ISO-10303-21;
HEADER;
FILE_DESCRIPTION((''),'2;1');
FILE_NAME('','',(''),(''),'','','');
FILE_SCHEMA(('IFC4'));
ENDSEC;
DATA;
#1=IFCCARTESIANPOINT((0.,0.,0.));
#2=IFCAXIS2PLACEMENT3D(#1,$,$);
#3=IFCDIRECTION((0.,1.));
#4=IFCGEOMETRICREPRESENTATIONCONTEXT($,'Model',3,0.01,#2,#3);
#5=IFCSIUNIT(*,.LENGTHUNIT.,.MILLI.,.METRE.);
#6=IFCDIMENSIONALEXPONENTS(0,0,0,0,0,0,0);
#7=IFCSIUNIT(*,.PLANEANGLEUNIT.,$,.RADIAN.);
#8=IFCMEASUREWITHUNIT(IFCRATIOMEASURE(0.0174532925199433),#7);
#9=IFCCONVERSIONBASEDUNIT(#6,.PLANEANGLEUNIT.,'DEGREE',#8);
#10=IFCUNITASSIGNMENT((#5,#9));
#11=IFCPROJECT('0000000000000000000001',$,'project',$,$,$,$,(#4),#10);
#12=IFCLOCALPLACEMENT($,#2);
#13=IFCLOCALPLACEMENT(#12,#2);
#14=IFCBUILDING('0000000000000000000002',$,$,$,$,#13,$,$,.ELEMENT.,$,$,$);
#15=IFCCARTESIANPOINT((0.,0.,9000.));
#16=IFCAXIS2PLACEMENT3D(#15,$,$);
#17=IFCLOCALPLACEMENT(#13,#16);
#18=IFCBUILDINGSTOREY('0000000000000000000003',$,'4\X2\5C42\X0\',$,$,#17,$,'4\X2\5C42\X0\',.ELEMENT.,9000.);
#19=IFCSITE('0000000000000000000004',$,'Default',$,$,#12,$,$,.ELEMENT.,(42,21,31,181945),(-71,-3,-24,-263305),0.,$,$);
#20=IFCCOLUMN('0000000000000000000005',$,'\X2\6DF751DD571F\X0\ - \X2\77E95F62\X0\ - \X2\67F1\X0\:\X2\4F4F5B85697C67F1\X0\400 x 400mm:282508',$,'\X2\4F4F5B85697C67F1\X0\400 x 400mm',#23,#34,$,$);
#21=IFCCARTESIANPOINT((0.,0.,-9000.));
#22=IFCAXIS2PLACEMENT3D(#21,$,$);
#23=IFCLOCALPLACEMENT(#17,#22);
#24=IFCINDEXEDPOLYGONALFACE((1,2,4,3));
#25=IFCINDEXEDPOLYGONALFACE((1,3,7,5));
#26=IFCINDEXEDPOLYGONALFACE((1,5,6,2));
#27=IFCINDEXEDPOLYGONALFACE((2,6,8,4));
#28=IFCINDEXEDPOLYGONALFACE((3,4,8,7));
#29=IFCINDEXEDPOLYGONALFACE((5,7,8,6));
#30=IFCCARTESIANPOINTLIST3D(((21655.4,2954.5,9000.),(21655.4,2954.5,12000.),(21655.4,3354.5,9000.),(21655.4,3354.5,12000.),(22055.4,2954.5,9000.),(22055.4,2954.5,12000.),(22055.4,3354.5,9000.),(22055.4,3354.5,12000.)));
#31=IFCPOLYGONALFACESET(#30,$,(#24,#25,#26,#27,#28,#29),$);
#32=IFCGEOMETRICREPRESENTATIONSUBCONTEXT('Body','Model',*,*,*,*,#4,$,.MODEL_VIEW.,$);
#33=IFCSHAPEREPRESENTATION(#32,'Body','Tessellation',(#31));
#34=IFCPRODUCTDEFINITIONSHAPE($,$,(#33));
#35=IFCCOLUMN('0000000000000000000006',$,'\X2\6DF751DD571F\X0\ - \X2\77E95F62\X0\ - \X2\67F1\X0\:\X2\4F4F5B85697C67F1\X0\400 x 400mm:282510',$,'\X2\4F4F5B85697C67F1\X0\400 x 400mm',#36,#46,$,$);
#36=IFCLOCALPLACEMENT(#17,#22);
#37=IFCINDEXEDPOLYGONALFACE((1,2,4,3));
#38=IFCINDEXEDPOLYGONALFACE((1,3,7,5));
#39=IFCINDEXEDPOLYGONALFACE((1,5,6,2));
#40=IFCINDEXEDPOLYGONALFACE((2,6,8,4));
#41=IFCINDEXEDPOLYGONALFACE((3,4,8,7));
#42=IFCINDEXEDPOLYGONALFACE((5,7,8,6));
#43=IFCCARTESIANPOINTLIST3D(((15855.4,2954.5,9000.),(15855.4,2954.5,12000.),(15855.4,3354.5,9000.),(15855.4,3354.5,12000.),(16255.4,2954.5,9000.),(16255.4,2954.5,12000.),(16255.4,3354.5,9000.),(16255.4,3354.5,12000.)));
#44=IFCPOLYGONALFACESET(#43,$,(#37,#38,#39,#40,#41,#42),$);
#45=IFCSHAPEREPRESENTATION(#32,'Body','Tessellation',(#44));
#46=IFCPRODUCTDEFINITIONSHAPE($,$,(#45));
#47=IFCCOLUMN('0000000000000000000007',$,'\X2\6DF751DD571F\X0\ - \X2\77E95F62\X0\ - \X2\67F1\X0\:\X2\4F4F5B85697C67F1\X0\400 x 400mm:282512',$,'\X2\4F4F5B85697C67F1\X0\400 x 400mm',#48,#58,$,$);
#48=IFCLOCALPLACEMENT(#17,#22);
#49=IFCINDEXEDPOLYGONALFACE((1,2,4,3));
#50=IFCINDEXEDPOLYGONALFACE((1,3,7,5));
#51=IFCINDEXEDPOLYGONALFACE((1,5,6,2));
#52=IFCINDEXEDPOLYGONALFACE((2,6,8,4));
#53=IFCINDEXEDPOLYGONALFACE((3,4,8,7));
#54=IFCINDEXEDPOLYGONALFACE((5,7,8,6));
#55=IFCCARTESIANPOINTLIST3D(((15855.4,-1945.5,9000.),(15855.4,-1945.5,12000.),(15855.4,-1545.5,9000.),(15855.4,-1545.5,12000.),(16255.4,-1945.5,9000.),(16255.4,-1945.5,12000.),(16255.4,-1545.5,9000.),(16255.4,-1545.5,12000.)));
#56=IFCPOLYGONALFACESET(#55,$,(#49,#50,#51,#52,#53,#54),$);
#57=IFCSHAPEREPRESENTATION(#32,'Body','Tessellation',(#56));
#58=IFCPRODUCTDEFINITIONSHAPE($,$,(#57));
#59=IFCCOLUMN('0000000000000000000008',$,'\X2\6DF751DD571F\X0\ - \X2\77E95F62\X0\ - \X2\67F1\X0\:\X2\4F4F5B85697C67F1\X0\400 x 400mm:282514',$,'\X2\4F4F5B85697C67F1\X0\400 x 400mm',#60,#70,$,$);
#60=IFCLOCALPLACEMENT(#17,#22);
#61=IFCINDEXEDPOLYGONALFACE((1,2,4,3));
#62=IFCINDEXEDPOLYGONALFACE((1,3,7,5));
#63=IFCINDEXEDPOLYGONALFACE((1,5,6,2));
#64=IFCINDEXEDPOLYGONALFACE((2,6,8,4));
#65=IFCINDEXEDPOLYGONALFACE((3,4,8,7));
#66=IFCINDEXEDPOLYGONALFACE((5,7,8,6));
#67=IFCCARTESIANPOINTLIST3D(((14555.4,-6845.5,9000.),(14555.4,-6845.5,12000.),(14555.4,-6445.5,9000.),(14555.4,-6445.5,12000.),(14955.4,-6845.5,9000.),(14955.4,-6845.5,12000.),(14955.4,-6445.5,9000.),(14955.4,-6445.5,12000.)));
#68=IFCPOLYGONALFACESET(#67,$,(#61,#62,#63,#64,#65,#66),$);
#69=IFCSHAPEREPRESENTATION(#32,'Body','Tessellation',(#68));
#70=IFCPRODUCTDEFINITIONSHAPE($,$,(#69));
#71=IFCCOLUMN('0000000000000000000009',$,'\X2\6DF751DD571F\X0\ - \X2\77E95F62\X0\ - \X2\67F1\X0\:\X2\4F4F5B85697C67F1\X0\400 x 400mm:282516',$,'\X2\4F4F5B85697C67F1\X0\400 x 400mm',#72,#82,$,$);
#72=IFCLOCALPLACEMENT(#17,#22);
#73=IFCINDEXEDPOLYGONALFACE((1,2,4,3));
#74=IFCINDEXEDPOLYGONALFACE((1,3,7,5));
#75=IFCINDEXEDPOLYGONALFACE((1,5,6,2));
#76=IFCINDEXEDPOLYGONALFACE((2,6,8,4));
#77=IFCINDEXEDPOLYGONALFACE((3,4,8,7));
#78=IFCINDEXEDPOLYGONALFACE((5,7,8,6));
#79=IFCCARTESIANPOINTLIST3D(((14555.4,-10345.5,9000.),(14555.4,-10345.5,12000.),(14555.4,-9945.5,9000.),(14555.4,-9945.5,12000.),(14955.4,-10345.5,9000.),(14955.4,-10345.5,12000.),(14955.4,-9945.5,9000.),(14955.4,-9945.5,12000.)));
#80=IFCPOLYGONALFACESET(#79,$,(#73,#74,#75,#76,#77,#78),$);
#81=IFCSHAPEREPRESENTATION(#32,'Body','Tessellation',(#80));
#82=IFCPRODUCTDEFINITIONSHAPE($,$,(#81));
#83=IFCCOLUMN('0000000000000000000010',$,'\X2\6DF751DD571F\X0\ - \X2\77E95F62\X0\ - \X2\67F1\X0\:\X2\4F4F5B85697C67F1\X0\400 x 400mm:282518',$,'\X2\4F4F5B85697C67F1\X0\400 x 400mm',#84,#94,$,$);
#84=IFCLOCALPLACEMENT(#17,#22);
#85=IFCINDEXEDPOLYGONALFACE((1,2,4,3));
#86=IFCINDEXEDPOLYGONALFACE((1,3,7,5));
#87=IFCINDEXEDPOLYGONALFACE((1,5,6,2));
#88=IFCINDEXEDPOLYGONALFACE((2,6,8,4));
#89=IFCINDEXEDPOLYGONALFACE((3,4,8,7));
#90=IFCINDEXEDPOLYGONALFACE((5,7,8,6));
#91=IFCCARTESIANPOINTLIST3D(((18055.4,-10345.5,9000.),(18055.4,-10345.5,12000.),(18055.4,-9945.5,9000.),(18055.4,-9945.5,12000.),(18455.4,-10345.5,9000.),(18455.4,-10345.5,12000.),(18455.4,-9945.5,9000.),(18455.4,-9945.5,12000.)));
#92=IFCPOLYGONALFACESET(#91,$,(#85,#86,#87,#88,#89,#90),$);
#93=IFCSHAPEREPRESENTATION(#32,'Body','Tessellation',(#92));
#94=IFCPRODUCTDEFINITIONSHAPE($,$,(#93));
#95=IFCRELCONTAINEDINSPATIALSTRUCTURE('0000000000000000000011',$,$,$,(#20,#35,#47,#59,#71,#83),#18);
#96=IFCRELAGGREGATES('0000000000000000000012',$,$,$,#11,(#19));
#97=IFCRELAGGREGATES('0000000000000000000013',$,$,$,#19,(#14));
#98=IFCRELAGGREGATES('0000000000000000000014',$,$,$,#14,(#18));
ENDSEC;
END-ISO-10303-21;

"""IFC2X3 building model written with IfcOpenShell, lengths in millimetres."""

from ifc_helpers import new_model, entity, si_unit, converted_unit, direction, frame, frame_2d, origin, origin_2d_with_axis, place, context, subcontext, project, spatial, rectangle, extrude, source, transform, mapped, element, save


model = new_model("IFC2X3")

# Units and contexts
model_context = context("Model", 3, precision=0.01, world=origin(), true_north=direction((0.0, 1.0)))
body_context = subcontext(model_context, "Body", "Model", "MODEL_VIEW")
ifc_project = project(units=[si_unit("LENGTHUNIT", "METRE", prefix="MILLI"), converted_unit("PLANEANGLEUNIT", "DEGREE", entity("IfcRatioMeasure", 0.0174532925199433), si_unit("PLANEANGLEUNIT", "RADIAN"), dimensions=[0, 0, 0, 0, 0, 0, 0])], contexts=[model_context])

# Site, building, storey
site_placement = place(None, origin())
site = spatial("IfcSite", under=ifc_project, at=site_placement, Name="Default", CompositionType="ELEMENT", RefLatitude=(42, 21, 31, 181945), RefLongitude=(-71, -3, -24, -263305), RefElevation=0.0)
building_placement = place(site_placement, origin())
building = spatial("IfcBuilding", under=site, at=building_placement, CompositionType="ELEMENT")
storey_placement = place(building_placement, frame((0.0, 0.0, 9000.0)))
storey = spatial("IfcBuildingStorey", under=building, at=storey_placement, Name="4层", LongName="4层", CompositionType="ELEMENT", Elevation=9000.0)

# Columns
shared_shape_1 = source(origin(), body_context, "Body", "SweptSolid", [
    extrude(rectangle(XDim=400.0, YDim=400.0, at=frame_2d((0.0, 0.0), x_axis=(1.0, 0.0))), frame((21855.4, 3154.5, 9000.0), z_axis=(0.0, 0.0, 1.0), x_axis=(0.0, -1.0, 0.0)), (0.0, 0.0, 1.0), 3000.0),
])
column_1_placement = place(storey_placement, frame((0.0, 0.0, -9000.0)))
element("IfcColumn", 1, at=column_1_placement, inside=storey, Name="混凝土 - 矩形 - 柱:住宅楼柱400 x 400mm:282508", ObjectType="住宅楼柱400 x 400mm", context=body_context, shape_type="MappedRepresentation", body=[
    mapped(shared_shape_1, transform((0.0, 0.0, 0.0), scale=1.0)),
])
shared_shape_2 = source(origin(), body_context, "Body", "SweptSolid", [
    extrude(rectangle(XDim=400.0, YDim=400.0, at=origin_2d_with_axis()), frame((16055.4, 3154.5, 9000.0), z_axis=(0.0, 0.0, 1.0), x_axis=(0.0, -1.0, 0.0)), (0.0, 0.0, 1.0), 3000.0),
])
column_2_placement = place(storey_placement, frame((0.0, 0.0, -9000.0)))
element("IfcColumn", 2, at=column_2_placement, inside=storey, Name="混凝土 - 矩形 - 柱:住宅楼柱400 x 400mm:282510", ObjectType="住宅楼柱400 x 400mm", context=body_context, shape_type="MappedRepresentation", body=[
    mapped(shared_shape_2, transform((0.0, 0.0, 0.0), scale=1.0)),
])
shared_shape_3 = source(origin(), body_context, "Body", "SweptSolid", [
    extrude(rectangle(XDim=400.0, YDim=400.0, at=origin_2d_with_axis()), frame((16055.4, -1745.5, 9000.0), z_axis=(0.0, 0.0, 1.0), x_axis=(0.0, -1.0, 0.0)), (0.0, 0.0, 1.0), 3000.0),
])
column_3_placement = place(storey_placement, frame((0.0, 0.0, -9000.0)))
element("IfcColumn", 3, at=column_3_placement, inside=storey, Name="混凝土 - 矩形 - 柱:住宅楼柱400 x 400mm:282512", ObjectType="住宅楼柱400 x 400mm", context=body_context, shape_type="MappedRepresentation", body=[
    mapped(shared_shape_3, transform((0.0, 0.0, 0.0), scale=1.0)),
])
shared_shape_4 = source(origin(), body_context, "Body", "SweptSolid", [
    extrude(rectangle(XDim=400.0, YDim=400.0, at=frame_2d((0.0, 0.0), x_axis=(1.0, 0.0))), frame((14755.4, -6645.5, 9000.0), z_axis=(0.0, 0.0, 1.0), x_axis=(0.0, -1.0, 0.0)), (0.0, 0.0, 1.0), 3000.0),
])
column_4_placement = place(storey_placement, frame((0.0, 0.0, -9000.0)))
element("IfcColumn", 4, at=column_4_placement, inside=storey, Name="混凝土 - 矩形 - 柱:住宅楼柱400 x 400mm:282514", ObjectType="住宅楼柱400 x 400mm", context=body_context, shape_type="MappedRepresentation", body=[
    mapped(shared_shape_4, transform((0.0, 0.0, 0.0), scale=1.0)),
])
shared_shape_5 = source(origin(), body_context, "Body", "SweptSolid", [
    extrude(rectangle(XDim=400.0, YDim=400.0, at=origin_2d_with_axis()), frame((14755.4, -10145.5, 9000.0), z_axis=(0.0, 0.0, 1.0), x_axis=(0.0, -1.0, 0.0)), (0.0, 0.0, 1.0), 3000.0),
])
column_5_placement = place(storey_placement, frame((0.0, 0.0, -9000.0)))
element("IfcColumn", 5, at=column_5_placement, inside=storey, Name="混凝土 - 矩形 - 柱:住宅楼柱400 x 400mm:282516", ObjectType="住宅楼柱400 x 400mm", context=body_context, shape_type="MappedRepresentation", body=[
    mapped(shared_shape_5, transform((0.0, 0.0, 0.0), scale=1.0)),
])
shared_shape_6 = source(origin(), body_context, "Body", "SweptSolid", [
    extrude(rectangle(XDim=400.0, YDim=400.0, at=origin_2d_with_axis()), frame((18255.4, -10145.5, 9000.0), z_axis=(0.0, 0.0, 1.0), x_axis=(0.0, -1.0, 0.0)), (0.0, 0.0, 1.0), 3000.0),
])
column_6_placement = place(storey_placement, frame((0.0, 0.0, -9000.0)))
element("IfcColumn", 6, at=column_6_placement, inside=storey, Name="混凝土 - 矩形 - 柱:住宅楼柱400 x 400mm:282518", ObjectType="住宅楼柱400 x 400mm", context=body_context, shape_type="MappedRepresentation", body=[
    mapped(shared_shape_6, transform((0.0, 0.0, 0.0), scale=1.0)),
])

save(model, "model.ifc")
